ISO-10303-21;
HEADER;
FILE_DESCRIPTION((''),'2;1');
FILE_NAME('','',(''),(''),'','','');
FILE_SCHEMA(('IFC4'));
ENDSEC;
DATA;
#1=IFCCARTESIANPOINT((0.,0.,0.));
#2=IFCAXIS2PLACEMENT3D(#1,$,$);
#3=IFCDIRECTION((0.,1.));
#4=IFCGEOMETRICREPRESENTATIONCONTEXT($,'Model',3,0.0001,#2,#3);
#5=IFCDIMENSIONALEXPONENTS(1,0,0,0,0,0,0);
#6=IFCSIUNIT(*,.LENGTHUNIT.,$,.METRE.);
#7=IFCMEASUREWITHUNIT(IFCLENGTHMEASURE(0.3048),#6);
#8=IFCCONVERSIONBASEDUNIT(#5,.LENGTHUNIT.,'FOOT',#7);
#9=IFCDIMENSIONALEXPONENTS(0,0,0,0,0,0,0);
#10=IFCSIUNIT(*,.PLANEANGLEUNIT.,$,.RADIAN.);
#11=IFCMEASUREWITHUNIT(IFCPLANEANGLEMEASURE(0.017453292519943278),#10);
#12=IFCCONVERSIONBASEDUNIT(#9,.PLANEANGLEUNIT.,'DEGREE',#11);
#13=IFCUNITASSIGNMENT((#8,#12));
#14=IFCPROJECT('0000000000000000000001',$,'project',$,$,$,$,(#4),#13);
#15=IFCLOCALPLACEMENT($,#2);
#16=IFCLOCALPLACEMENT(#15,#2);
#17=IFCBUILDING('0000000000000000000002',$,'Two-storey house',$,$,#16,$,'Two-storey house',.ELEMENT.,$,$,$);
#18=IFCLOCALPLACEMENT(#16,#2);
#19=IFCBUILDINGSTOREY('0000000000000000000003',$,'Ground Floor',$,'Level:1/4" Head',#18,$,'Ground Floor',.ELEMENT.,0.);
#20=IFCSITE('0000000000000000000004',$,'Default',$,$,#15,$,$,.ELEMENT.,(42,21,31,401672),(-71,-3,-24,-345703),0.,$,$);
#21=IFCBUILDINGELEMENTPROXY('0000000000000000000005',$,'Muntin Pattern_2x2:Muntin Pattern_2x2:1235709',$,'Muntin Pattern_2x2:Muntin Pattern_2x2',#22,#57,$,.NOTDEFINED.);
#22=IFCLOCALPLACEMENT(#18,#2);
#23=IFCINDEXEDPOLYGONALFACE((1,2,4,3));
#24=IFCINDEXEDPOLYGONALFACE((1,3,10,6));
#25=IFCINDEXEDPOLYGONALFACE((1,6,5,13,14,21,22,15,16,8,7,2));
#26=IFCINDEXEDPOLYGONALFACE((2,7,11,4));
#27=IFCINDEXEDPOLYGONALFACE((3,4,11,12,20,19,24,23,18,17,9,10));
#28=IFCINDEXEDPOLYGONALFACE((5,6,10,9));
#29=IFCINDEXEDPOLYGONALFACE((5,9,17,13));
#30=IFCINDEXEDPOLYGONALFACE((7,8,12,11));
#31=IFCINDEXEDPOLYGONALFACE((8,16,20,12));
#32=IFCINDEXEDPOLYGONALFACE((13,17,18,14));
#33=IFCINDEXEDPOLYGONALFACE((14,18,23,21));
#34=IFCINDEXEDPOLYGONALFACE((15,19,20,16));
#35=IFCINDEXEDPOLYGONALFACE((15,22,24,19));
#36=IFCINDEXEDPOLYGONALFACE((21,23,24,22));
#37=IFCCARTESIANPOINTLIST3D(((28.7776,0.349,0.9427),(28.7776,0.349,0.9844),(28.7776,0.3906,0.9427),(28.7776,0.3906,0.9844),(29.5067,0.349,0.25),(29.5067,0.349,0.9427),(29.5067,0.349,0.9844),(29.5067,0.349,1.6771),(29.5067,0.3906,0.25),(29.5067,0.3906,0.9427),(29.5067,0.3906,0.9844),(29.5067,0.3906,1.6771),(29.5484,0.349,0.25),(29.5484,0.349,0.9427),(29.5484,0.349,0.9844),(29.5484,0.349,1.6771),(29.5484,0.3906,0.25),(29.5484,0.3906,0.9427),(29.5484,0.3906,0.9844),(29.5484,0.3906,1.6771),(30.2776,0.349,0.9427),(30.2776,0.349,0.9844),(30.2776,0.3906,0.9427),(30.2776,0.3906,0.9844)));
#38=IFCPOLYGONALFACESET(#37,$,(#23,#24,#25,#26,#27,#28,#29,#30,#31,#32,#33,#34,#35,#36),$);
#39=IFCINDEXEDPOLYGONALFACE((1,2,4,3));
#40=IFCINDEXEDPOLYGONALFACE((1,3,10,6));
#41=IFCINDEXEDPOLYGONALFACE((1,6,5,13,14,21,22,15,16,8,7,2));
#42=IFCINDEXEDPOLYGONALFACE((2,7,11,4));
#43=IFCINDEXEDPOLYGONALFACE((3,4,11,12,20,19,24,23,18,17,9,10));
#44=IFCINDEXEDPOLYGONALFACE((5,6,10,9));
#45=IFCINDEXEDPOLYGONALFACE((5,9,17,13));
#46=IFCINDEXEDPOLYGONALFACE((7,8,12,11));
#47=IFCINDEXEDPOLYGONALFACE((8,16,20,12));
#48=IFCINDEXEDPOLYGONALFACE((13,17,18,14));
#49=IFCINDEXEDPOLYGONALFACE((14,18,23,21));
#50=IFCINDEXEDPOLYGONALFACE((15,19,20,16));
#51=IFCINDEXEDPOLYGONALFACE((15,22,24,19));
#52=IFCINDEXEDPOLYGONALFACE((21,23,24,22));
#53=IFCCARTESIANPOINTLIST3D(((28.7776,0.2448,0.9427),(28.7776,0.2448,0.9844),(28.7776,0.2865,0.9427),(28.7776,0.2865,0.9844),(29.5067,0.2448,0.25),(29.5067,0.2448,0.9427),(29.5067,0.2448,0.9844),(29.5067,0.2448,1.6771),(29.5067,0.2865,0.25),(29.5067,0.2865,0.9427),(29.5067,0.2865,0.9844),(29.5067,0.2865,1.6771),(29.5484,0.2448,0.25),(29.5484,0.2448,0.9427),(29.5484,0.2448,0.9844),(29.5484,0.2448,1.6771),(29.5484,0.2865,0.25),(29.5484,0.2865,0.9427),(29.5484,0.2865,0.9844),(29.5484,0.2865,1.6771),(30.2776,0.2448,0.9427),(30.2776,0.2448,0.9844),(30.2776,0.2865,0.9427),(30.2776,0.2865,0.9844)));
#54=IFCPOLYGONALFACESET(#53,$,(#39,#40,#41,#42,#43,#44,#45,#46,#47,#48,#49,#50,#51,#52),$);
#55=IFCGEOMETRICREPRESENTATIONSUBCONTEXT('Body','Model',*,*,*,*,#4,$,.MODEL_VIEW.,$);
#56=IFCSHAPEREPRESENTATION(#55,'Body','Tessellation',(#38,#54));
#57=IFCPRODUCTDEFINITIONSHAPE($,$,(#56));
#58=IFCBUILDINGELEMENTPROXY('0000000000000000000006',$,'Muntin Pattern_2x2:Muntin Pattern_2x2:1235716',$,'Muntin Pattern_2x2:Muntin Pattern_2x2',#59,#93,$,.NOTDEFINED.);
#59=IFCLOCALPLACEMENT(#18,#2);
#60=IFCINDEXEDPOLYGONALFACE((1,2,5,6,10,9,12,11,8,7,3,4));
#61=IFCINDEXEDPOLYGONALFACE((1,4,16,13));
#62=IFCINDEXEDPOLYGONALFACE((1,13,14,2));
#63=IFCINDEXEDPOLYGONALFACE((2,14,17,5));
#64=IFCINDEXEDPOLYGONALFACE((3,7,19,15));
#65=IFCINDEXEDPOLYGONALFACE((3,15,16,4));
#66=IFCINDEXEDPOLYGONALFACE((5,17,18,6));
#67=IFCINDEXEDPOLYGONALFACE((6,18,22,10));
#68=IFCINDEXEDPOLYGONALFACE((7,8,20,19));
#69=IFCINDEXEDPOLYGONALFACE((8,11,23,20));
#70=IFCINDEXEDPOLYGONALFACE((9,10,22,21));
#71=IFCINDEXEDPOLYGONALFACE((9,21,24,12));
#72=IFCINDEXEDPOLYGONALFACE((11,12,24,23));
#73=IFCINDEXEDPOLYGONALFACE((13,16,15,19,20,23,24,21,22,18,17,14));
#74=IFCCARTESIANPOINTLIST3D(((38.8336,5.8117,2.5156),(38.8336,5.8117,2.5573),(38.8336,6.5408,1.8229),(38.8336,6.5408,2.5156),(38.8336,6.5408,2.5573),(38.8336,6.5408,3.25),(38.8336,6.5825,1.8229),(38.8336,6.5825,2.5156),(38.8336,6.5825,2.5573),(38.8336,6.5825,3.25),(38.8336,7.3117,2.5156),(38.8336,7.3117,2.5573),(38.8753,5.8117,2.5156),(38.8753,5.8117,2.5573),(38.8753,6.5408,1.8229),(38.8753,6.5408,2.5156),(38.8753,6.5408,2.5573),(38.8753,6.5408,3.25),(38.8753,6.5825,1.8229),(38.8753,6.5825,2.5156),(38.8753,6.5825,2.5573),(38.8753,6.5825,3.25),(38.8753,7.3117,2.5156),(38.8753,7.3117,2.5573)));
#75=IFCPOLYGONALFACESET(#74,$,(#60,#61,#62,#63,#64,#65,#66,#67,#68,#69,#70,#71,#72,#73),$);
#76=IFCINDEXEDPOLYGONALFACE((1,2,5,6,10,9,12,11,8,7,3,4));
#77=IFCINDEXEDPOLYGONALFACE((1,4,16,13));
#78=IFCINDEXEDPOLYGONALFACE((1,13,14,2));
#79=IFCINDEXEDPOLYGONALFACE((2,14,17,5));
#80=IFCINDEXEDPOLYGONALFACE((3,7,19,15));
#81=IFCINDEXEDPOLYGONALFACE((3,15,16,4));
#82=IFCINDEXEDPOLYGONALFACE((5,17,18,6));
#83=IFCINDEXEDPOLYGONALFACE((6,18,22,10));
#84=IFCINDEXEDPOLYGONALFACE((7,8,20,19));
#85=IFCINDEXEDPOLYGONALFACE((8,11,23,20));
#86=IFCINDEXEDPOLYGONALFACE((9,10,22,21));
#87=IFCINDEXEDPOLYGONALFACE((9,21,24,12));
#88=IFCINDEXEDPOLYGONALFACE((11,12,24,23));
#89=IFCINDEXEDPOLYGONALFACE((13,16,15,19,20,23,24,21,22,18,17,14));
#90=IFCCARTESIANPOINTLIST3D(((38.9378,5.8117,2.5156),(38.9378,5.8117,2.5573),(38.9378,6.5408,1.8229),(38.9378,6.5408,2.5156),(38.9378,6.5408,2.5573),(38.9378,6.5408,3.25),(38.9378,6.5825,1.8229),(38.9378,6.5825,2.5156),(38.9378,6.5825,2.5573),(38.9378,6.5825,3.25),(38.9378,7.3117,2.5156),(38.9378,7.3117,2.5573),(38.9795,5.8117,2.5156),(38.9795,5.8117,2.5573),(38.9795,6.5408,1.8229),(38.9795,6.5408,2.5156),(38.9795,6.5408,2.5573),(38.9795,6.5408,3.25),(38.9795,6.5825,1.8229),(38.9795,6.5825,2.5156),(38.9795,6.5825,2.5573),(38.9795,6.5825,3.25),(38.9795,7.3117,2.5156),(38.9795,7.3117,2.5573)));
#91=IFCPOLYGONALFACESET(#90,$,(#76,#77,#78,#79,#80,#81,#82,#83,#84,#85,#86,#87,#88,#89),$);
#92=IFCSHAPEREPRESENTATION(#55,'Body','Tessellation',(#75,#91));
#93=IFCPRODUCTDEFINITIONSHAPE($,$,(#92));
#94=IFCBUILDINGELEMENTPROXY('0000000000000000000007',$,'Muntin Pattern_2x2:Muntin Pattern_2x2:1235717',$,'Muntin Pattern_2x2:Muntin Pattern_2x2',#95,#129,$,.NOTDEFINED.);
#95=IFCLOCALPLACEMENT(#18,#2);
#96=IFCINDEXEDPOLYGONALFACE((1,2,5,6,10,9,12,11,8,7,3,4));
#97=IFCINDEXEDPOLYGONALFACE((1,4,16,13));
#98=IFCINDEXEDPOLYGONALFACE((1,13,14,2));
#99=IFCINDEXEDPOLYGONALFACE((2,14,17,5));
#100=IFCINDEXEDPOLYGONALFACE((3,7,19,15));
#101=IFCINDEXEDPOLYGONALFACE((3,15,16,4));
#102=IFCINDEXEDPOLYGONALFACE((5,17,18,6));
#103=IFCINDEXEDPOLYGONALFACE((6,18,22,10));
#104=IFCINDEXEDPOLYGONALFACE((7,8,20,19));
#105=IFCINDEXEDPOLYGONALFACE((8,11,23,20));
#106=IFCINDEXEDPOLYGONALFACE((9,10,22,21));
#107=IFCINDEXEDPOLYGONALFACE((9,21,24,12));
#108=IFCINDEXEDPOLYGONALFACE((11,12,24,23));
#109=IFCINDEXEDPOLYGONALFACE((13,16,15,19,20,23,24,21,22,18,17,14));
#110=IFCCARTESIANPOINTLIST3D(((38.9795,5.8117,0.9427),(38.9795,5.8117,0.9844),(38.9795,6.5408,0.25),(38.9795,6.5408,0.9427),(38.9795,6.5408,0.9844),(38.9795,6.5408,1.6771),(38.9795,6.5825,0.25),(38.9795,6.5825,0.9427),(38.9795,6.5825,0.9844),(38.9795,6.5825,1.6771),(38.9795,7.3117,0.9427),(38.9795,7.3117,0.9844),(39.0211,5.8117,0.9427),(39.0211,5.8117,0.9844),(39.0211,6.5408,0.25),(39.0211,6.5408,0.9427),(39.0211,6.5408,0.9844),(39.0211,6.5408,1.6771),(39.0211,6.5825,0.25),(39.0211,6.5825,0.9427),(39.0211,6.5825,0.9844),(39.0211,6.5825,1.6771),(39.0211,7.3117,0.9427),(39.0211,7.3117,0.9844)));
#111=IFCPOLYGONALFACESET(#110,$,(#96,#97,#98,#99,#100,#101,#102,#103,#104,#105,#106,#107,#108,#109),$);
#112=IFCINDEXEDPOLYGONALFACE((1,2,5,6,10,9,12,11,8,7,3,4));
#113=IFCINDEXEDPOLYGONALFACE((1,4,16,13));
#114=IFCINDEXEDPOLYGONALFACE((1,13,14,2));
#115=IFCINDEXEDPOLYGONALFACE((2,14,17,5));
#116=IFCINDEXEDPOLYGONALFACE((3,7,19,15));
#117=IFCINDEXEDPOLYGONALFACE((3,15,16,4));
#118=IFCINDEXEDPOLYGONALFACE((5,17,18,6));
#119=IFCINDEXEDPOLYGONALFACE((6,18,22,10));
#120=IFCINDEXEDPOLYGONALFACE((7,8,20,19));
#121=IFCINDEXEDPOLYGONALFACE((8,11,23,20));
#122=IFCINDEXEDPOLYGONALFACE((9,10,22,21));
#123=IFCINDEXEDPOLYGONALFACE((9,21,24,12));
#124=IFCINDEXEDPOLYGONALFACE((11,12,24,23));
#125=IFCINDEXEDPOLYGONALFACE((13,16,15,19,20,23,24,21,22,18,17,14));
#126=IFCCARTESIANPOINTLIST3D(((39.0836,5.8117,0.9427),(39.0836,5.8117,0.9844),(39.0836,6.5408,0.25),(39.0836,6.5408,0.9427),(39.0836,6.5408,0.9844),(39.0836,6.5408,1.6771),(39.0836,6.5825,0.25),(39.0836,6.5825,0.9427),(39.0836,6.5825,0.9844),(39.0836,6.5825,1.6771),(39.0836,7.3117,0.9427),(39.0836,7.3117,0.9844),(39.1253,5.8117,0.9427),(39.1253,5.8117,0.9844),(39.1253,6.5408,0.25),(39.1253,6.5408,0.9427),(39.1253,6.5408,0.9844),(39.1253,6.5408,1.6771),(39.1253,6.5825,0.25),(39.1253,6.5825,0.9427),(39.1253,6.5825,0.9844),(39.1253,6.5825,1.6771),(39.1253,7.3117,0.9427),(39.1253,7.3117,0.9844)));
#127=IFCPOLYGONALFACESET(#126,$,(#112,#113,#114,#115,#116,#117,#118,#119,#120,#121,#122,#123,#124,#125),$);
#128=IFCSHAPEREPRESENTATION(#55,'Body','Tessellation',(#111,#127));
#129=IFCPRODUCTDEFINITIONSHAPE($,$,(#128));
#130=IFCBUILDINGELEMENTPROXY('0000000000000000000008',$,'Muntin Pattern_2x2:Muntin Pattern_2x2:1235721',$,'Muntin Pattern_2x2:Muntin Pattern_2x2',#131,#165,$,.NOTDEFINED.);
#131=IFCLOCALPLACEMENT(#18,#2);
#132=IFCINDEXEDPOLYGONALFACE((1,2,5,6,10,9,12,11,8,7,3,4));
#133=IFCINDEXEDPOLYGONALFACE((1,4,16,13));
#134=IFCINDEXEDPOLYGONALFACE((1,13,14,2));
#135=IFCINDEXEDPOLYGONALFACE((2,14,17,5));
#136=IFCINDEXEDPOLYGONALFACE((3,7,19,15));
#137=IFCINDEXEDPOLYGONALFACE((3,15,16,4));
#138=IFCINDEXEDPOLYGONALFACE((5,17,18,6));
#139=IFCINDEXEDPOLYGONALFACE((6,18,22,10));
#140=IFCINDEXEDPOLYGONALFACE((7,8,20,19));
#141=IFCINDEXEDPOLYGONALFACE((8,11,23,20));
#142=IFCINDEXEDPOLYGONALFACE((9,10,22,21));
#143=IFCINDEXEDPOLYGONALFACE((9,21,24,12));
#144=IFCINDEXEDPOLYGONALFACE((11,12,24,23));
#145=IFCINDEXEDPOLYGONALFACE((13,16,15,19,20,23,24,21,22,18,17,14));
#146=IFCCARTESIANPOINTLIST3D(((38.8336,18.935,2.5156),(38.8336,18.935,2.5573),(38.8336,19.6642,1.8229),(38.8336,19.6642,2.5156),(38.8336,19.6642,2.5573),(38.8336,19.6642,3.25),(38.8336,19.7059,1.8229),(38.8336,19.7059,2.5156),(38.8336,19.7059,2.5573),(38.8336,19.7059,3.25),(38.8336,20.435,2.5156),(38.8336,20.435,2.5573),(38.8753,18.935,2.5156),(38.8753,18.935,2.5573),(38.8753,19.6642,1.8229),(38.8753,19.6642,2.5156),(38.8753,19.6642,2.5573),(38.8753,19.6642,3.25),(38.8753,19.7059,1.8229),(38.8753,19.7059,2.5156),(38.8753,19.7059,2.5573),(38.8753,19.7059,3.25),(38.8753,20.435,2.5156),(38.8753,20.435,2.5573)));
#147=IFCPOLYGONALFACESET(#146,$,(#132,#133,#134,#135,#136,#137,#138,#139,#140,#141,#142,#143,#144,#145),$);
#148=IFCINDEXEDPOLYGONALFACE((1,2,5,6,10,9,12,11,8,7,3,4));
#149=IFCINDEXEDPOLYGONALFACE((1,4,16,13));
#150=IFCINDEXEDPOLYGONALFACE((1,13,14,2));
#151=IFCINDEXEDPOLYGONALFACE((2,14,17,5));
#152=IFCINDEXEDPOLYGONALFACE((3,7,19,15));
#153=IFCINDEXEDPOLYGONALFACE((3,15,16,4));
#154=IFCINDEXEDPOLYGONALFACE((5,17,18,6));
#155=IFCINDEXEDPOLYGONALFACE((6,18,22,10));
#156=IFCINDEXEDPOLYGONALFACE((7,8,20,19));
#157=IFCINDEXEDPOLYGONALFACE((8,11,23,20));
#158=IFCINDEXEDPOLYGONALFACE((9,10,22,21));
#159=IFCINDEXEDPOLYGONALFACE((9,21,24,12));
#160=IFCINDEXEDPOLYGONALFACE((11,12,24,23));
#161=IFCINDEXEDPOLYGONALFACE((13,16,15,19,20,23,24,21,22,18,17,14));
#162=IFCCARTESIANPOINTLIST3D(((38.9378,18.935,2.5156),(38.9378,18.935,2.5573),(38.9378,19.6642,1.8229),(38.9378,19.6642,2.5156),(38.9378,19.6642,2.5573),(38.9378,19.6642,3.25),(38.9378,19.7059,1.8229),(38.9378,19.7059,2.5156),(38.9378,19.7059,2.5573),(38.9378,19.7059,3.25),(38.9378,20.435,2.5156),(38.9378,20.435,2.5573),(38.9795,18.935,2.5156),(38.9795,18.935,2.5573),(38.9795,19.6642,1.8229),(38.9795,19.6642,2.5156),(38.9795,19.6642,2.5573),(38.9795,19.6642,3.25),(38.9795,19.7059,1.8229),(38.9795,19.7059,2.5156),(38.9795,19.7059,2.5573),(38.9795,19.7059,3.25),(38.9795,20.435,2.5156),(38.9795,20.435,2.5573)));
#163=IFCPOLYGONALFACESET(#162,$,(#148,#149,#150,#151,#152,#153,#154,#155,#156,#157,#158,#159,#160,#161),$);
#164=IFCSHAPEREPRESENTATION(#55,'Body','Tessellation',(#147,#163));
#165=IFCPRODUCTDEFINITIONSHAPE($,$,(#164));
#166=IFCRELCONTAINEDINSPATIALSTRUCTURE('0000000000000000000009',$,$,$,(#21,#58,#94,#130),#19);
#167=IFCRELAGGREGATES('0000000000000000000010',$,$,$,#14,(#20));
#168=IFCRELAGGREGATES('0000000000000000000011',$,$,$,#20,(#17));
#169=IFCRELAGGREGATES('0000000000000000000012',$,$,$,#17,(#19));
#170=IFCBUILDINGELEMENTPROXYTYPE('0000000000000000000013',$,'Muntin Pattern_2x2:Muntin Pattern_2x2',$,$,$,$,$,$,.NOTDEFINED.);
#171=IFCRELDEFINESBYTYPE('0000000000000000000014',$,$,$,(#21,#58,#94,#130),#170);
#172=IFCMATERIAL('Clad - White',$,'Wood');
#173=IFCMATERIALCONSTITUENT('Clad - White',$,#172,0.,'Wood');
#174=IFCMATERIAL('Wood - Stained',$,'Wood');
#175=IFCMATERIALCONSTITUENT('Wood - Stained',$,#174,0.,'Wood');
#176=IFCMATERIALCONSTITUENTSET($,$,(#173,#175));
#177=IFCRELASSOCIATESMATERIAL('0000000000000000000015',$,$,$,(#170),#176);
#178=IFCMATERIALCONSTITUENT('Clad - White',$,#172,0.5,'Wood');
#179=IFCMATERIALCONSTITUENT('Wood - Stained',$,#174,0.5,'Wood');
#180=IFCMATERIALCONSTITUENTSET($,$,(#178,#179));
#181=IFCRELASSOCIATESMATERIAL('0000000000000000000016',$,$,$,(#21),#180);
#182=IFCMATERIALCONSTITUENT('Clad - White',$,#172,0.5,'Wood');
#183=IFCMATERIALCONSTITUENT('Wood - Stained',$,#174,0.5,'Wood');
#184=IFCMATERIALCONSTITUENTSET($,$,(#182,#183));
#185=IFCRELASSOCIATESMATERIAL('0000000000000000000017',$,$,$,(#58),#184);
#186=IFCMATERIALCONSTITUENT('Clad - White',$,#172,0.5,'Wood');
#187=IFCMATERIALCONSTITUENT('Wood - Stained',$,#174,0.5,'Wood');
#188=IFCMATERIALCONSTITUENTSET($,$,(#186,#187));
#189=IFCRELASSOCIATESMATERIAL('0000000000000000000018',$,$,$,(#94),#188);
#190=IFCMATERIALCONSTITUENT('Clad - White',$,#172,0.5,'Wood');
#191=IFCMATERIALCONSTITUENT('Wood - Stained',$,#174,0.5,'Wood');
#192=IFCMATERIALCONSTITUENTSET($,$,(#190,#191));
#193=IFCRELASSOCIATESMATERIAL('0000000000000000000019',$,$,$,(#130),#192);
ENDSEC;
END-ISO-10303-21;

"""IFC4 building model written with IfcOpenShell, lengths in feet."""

from ifc_helpers import new_model, entity, si_unit, converted_unit, direction, frame, origin, place, context, subcontext, project, spatial, indexed_curve, outline, extrude, source, transform, mapped, material, constituent, constituent_set, type_object, type_shapes, element, save


model = new_model("IFC4")

# Units and contexts
model_context = context("Model", 3, precision=0.0001, world=origin(), true_north=direction((0.0, 1.0)))
body_context = subcontext(model_context, "Body", "Model", "MODEL_VIEW")
ifc_project = project(units=[converted_unit("LENGTHUNIT", "FOOT", entity("IfcLengthMeasure", 0.3048), si_unit("LENGTHUNIT", "METRE"), dimensions=[1, 0, 0, 0, 0, 0, 0]), converted_unit("PLANEANGLEUNIT", "DEGREE", entity("IfcPlaneAngleMeasure", 0.017453292519943278), si_unit("PLANEANGLEUNIT", "RADIAN"), dimensions=[0, 0, 0, 0, 0, 0, 0])], contexts=[model_context])

# Site, building, storey
site_placement = place(None, origin())
site = spatial("IfcSite", under=ifc_project, at=site_placement, Name="Default", CompositionType="ELEMENT", RefLatitude=(42, 21, 31, 401672), RefLongitude=(-71, -3, -24, -345703), RefElevation=0.0)
building_placement = place(site_placement, origin())
building = spatial("IfcBuilding", under=site, at=building_placement, Name="Two-storey house", LongName="Two-storey house", CompositionType="ELEMENT")
storey_placement = place(building_placement, origin())
storey = spatial("IfcBuildingStorey", under=building, at=storey_placement, Name="Ground Floor", ObjectType="Level:1/4\" Head", LongName="Ground Floor", CompositionType="ELEMENT", Elevation=0.0)

# Shared definitions
ifc_material_1 = material(Name="Wood - Stained", Category="Wood")

# Building element proxies
ifc_material_2 = material(Name="Clad - White", Category="Wood")
ifc_constituent_1 = constituent(ifc_material_2, Name="Clad - White", Category="Wood", fraction=0.5)
ifc_constituent_2 = constituent(ifc_material_1, Name="Wood - Stained", Category="Wood", fraction=0.5)
ifc_constituent_set_1 = constituent_set(constituents=[ifc_constituent_1, ifc_constituent_2])
ifc_constituent_3 = constituent(ifc_material_2, Name="Clad - White", Category="Wood", fraction=0.0)
ifc_constituent_4 = constituent(ifc_material_1, Name="Wood - Stained", Category="Wood", fraction=0.0)
ifc_constituent_set_2 = constituent_set(constituents=[ifc_constituent_3, ifc_constituent_4])
building_element_proxy_type_1 = type_object("IfcBuildingElementProxyType", Name="Muntin Pattern_2x2:Muntin Pattern_2x2", PredefinedType="NOTDEFINED", material=ifc_constituent_set_2)
shared_shape_1 = source(origin(), body_context, "Body", "SweptSolid", [
    extrude(outline(indexed_curve([(0.0208, -0.0208), (0.7135, -0.0208), (0.7135, 0.0208), (0.0208, 0.0208), (0.0208, 0.75), (-0.0208, 0.75), (-0.0208, 0.0208), (-0.7135, 0.0208), (-0.7135, -0.0208), (-0.0208, -0.0208), (-0.0208, -0.75), (0.0208, -0.75), (0.0208, -0.0208)], self_intersect=False)), frame((0.0, 0.0312, 0.7135), z_axis=(0.0, 1.0, 0.0), x_axis=(0.0, 0.0, 1.0)), (0.0, 0.0, 1.0), 0.0417),
    extrude(outline(indexed_curve([(0.0208, -0.0208), (0.7135, -0.0208), (0.7135, 0.0208), (0.0208, 0.0208), (0.0208, 0.75), (-0.0208, 0.75), (-0.0208, 0.0208), (-0.7135, 0.0208), (-0.7135, -0.0208), (-0.0208, -0.0208), (-0.0208, -0.75), (0.0208, -0.75), (0.0208, -0.0208)], self_intersect=False)), frame((0.0, -0.0729, 0.7135), z_axis=(0.0, 1.0, 0.0), x_axis=(0.0, 0.0, 1.0)), (0.0, 0.0, 1.0), 0.0417),
])
type_shapes(building_element_proxy_type_1, [shared_shape_1])
proxy_1_placement = place(storey_placement, frame((29.5276, 0.3177, 0.25)))
element("IfcBuildingElementProxy", 1, at=proxy_1_placement, inside=storey, type_object=building_element_proxy_type_1, material=ifc_constituent_set_1, Name="Muntin Pattern_2x2:Muntin Pattern_2x2:1235709", ObjectType="Muntin Pattern_2x2:Muntin Pattern_2x2", PredefinedType="NOTDEFINED", context=body_context, shape_type="MappedRepresentation", body=[
    mapped(shared_shape_1, transform((0.0, 0.0, 0.0), scale=1.0)),
])
ifc_constituent_5 = constituent(ifc_material_2, Name="Clad - White", Category="Wood", fraction=0.5)
ifc_constituent_6 = constituent(ifc_material_1, Name="Wood - Stained", Category="Wood", fraction=0.5)
ifc_constituent_set_3 = constituent_set(constituents=[ifc_constituent_5, ifc_constituent_6])
proxy_2_placement = place(storey_placement, frame((38.9065, 6.5617, 1.8229), z_axis=(0.0, 0.0, 1.0), x_axis=(0.0, 1.0, 0.0)))
element("IfcBuildingElementProxy", 2, at=proxy_2_placement, inside=storey, type_object=building_element_proxy_type_1, material=ifc_constituent_set_3, Name="Muntin Pattern_2x2:Muntin Pattern_2x2:1235716", ObjectType="Muntin Pattern_2x2:Muntin Pattern_2x2", PredefinedType="NOTDEFINED", context=body_context, shape_type="MappedRepresentation", body=[
    mapped(shared_shape_1, transform((0.0, 0.0, 0.0), scale=1.0)),
])
ifc_constituent_7 = constituent(ifc_material_2, Name="Clad - White", Category="Wood", fraction=0.5)
ifc_constituent_8 = constituent(ifc_material_1, Name="Wood - Stained", Category="Wood", fraction=0.5)
ifc_constituent_set_4 = constituent_set(constituents=[ifc_constituent_7, ifc_constituent_8])
proxy_3_placement = place(storey_placement, frame((39.0524, 6.5617, 0.25), z_axis=(0.0, 0.0, 1.0), x_axis=(0.0, 1.0, 0.0)))
element("IfcBuildingElementProxy", 3, at=proxy_3_placement, inside=storey, type_object=building_element_proxy_type_1, material=ifc_constituent_set_4, Name="Muntin Pattern_2x2:Muntin Pattern_2x2:1235717", ObjectType="Muntin Pattern_2x2:Muntin Pattern_2x2", PredefinedType="NOTDEFINED", context=body_context, shape_type="MappedRepresentation", body=[
    mapped(shared_shape_1, transform((0.0, 0.0, 0.0), scale=1.0)),
])
ifc_constituent_9 = constituent(ifc_material_2, Name="Clad - White", Category="Wood", fraction=0.5)
ifc_constituent_10 = constituent(ifc_material_1, Name="Wood - Stained", Category="Wood", fraction=0.5)
ifc_constituent_set_5 = constituent_set(constituents=[ifc_constituent_9, ifc_constituent_10])
proxy_4_placement = place(storey_placement, frame((38.9065, 19.685, 1.8229), z_axis=(0.0, 0.0, 1.0), x_axis=(0.0, 1.0, 0.0)))
element("IfcBuildingElementProxy", 4, at=proxy_4_placement, inside=storey, type_object=building_element_proxy_type_1, material=ifc_constituent_set_5, Name="Muntin Pattern_2x2:Muntin Pattern_2x2:1235721", ObjectType="Muntin Pattern_2x2:Muntin Pattern_2x2", PredefinedType="NOTDEFINED", context=body_context, shape_type="MappedRepresentation", body=[
    mapped(shared_shape_1, transform((0.0, 0.0, 0.0), scale=1.0)),
])

save(model, "model.ifc")
